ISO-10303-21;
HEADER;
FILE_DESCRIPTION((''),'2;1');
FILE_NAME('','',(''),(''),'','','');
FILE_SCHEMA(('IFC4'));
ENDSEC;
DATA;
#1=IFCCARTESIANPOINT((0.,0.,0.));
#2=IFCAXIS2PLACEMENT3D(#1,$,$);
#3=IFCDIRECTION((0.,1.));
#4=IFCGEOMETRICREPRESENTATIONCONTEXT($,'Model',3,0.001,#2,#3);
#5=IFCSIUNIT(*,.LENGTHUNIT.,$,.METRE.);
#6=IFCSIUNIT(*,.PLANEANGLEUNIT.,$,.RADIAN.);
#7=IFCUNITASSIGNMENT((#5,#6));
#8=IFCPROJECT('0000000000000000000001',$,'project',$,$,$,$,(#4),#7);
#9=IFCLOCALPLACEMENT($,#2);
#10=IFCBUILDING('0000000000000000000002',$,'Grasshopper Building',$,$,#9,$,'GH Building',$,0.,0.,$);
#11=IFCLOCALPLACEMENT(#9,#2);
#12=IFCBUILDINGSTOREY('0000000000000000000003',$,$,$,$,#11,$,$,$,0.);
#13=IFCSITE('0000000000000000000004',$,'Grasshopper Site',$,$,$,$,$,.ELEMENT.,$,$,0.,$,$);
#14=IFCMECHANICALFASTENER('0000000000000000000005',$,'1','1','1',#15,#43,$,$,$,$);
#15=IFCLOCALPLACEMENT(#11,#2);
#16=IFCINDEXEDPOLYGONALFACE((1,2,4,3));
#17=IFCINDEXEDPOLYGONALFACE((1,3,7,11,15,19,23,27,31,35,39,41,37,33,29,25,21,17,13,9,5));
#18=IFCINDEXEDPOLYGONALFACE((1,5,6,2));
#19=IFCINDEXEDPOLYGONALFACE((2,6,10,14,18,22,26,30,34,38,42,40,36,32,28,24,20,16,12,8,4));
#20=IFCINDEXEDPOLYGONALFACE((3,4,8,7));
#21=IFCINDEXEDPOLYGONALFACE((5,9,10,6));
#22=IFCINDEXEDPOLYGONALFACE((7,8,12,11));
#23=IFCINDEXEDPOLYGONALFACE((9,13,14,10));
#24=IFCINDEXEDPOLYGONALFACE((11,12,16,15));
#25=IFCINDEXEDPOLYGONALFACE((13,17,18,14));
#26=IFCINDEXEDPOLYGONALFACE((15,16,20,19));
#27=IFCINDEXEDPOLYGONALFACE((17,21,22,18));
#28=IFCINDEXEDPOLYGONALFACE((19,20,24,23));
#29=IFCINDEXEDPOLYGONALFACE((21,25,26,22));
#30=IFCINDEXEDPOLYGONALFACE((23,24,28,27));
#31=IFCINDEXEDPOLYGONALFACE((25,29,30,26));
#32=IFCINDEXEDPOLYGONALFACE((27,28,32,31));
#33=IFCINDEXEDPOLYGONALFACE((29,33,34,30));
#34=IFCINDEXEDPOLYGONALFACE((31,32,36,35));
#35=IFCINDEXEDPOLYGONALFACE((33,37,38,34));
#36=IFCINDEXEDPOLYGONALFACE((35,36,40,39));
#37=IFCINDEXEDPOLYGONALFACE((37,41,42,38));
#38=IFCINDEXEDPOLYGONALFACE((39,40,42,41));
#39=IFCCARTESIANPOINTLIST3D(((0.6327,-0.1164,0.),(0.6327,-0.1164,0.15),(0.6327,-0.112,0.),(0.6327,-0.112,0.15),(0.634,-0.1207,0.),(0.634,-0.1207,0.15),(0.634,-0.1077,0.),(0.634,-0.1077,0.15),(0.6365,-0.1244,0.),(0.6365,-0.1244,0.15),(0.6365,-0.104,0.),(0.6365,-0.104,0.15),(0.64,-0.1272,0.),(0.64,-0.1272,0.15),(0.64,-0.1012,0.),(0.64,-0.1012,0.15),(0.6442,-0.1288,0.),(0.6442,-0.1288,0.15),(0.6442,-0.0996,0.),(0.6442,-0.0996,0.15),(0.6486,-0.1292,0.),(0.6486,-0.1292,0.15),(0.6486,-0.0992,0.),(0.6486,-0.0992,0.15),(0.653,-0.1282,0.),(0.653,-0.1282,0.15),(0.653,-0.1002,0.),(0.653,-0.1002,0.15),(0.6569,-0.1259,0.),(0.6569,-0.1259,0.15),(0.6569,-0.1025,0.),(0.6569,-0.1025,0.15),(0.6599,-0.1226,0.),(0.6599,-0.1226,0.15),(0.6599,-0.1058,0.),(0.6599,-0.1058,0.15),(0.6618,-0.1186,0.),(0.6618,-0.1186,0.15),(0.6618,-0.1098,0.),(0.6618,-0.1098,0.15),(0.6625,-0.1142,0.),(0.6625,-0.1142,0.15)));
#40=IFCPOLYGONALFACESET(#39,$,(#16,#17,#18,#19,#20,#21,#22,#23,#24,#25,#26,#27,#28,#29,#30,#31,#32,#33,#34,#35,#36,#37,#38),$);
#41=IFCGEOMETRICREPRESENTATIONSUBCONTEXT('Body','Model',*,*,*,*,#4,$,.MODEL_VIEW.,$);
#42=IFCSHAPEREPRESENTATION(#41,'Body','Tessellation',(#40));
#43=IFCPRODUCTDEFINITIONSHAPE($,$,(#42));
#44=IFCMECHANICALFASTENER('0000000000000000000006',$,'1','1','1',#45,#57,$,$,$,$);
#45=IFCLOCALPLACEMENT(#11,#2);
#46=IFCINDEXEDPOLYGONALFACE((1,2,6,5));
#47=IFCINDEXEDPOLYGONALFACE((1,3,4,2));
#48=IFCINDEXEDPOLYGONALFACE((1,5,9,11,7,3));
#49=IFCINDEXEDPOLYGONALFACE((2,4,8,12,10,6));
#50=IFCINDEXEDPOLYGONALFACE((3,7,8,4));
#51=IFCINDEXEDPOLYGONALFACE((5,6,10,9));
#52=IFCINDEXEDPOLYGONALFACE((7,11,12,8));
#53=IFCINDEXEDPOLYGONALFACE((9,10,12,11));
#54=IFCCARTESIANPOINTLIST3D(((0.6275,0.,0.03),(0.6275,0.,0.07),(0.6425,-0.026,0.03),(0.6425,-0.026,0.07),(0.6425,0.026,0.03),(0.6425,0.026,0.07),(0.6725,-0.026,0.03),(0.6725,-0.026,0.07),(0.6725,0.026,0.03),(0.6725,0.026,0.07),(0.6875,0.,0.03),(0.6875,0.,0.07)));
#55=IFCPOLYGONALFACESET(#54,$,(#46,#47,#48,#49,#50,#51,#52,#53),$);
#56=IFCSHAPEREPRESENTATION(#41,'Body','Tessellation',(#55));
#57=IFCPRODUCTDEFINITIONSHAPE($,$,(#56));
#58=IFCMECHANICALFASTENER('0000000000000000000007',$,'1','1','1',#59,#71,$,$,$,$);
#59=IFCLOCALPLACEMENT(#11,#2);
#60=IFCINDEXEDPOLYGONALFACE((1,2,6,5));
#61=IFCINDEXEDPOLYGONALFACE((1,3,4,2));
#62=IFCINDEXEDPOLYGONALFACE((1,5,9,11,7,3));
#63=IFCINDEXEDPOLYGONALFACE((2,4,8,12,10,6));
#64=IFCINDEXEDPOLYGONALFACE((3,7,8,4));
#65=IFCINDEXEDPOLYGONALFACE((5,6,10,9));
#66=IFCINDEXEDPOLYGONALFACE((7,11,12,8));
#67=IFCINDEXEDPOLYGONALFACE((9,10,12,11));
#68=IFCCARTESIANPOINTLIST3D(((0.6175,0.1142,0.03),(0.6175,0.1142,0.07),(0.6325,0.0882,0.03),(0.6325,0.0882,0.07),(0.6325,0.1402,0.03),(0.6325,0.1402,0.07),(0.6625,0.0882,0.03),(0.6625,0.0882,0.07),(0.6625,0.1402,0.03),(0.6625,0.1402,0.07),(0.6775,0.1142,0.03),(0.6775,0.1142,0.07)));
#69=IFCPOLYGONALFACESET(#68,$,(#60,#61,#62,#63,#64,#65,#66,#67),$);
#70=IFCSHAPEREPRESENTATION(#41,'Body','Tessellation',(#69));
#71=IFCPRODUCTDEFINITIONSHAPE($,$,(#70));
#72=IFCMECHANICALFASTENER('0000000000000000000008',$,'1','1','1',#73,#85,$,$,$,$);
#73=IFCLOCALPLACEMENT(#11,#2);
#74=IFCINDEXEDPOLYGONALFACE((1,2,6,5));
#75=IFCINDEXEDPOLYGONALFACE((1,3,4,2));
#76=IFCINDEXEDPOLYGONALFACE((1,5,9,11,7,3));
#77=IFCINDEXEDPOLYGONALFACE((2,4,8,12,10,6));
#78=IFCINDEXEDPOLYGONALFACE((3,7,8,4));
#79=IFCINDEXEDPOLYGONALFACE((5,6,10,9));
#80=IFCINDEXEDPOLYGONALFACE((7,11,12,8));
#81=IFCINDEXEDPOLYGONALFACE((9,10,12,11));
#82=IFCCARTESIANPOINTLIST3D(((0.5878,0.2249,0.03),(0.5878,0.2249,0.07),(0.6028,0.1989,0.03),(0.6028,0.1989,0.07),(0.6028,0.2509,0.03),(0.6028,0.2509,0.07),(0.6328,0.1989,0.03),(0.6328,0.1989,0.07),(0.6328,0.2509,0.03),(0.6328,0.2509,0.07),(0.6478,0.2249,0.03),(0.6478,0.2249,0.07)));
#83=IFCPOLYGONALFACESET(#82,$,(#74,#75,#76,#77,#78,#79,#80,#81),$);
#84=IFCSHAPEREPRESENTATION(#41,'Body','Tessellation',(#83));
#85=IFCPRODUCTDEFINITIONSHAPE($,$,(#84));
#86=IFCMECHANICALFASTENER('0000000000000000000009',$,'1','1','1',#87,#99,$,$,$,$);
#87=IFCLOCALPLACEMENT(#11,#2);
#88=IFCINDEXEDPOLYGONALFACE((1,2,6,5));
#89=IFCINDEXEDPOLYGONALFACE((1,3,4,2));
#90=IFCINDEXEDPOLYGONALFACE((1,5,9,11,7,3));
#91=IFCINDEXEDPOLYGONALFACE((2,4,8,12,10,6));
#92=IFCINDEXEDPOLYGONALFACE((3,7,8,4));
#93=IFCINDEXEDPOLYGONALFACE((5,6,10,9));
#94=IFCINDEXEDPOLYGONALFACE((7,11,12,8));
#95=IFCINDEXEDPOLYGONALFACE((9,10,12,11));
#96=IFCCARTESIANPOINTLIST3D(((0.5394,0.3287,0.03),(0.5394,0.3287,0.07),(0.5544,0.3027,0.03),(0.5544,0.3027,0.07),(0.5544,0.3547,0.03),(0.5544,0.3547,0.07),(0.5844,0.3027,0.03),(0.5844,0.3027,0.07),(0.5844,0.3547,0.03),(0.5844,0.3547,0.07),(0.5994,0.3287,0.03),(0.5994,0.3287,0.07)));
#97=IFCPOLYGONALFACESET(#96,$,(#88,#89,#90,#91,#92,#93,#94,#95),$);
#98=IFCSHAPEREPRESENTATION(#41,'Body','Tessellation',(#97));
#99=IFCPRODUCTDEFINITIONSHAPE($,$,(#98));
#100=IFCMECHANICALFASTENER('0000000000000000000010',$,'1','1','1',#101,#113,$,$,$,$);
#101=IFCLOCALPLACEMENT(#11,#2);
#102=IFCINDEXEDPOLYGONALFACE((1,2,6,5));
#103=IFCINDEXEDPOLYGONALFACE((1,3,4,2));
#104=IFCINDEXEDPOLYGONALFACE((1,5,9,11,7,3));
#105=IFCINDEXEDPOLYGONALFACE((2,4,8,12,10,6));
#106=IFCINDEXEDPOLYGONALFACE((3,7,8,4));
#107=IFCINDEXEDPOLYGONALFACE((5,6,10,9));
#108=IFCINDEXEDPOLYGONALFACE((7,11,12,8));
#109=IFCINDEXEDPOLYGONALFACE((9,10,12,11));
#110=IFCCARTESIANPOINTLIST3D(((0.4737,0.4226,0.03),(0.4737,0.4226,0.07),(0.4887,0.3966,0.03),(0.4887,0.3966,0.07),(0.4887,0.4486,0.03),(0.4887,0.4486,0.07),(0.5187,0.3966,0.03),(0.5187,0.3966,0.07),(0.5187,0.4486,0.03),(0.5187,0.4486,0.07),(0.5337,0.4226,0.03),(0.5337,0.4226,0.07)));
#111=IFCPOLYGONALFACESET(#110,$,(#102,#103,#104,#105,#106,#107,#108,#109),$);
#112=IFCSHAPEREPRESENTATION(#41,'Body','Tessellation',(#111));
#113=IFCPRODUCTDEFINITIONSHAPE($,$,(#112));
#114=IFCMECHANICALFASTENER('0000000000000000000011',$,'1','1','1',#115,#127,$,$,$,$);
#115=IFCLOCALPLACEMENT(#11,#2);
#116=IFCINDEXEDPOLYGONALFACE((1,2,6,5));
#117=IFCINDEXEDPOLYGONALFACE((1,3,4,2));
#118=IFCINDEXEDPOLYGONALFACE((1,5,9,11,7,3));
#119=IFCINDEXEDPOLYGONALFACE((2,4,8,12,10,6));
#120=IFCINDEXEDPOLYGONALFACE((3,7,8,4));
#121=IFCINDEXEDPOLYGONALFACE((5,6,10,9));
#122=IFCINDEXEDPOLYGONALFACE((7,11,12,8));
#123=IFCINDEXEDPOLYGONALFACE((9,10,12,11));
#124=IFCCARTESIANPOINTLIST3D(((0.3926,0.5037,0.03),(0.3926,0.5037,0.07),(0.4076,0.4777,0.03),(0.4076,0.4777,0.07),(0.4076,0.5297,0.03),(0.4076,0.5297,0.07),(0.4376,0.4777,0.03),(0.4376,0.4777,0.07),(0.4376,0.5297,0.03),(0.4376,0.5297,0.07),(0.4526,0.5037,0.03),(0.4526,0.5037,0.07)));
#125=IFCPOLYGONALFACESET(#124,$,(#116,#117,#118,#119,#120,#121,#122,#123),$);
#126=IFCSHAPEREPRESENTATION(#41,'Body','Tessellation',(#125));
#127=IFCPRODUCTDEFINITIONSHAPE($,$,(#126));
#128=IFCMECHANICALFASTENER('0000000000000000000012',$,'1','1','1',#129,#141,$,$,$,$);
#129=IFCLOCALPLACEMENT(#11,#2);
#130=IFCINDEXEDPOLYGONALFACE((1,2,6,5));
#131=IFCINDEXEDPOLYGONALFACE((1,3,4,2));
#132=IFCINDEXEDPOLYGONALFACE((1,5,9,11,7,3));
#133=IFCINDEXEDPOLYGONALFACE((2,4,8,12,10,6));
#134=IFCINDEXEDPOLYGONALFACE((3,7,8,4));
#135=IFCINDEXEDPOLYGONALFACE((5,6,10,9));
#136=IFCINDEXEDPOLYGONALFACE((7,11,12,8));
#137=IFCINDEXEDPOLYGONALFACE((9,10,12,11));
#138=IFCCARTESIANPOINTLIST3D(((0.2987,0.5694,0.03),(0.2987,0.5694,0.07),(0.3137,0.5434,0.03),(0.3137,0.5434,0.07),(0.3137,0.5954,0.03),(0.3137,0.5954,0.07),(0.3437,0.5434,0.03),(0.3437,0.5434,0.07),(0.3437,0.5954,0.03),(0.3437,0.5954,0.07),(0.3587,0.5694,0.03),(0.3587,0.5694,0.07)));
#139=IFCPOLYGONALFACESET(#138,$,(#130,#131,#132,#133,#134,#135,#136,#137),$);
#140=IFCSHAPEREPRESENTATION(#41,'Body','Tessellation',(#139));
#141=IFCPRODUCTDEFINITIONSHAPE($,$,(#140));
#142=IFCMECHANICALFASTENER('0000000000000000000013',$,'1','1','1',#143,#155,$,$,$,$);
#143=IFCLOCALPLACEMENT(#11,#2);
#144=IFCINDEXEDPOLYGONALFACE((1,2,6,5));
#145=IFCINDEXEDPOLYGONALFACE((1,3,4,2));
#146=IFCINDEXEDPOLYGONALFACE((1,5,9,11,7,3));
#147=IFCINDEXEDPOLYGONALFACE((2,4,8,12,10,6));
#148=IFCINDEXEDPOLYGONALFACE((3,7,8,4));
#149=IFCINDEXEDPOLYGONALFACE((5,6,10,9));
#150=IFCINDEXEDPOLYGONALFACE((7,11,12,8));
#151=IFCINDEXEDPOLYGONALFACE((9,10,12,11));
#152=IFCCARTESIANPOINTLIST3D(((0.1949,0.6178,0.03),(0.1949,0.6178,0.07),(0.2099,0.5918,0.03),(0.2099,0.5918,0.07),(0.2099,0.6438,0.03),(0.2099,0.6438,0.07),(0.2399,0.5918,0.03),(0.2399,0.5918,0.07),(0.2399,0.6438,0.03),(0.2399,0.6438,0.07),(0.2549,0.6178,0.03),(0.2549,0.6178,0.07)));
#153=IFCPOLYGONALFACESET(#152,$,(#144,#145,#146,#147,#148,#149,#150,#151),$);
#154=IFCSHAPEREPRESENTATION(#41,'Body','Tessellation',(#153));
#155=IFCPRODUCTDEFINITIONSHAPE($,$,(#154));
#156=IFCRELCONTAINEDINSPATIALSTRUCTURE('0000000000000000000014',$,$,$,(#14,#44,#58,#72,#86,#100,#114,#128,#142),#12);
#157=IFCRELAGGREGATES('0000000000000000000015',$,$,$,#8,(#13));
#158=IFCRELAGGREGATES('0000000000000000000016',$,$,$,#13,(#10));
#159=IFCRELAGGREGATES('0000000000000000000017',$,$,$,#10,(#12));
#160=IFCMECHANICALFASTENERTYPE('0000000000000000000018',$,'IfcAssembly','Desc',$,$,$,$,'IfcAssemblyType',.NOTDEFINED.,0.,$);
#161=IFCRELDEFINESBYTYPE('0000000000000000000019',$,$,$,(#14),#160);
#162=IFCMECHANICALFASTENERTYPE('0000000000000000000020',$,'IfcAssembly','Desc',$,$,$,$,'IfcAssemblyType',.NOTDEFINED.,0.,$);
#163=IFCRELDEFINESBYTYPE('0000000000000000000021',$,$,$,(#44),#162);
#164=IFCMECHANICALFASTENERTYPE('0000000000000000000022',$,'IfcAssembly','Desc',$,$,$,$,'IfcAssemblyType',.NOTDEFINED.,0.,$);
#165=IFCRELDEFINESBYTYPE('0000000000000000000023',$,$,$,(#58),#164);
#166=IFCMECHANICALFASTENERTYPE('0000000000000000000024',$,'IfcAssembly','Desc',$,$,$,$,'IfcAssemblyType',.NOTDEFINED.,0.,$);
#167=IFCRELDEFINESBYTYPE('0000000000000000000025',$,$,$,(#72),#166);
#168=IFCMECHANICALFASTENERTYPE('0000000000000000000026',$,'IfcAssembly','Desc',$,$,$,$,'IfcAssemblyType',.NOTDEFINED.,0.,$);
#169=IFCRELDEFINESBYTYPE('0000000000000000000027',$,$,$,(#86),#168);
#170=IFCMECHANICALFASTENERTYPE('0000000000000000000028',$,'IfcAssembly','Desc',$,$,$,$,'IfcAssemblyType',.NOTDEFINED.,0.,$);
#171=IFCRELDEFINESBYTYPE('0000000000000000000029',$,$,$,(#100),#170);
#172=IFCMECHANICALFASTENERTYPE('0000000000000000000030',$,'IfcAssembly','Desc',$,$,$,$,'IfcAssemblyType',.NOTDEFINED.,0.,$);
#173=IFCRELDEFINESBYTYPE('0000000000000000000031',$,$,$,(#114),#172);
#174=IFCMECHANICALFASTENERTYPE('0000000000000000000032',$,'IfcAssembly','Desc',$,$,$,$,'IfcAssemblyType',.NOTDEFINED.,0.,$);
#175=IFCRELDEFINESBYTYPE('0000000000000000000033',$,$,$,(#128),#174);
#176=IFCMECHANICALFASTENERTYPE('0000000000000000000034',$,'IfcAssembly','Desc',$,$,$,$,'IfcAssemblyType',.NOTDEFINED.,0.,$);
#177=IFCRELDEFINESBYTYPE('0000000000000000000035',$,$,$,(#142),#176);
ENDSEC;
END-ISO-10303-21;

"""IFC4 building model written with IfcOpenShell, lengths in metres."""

from ifc_helpers import new_model, si_unit, direction, frame, origin, place, context, subcontext, project, spatial, indexed_curve, circle, outline, extrude, source, transform, mapped, type_object, type_shapes, element, save


model = new_model("IFC4")

# Units and contexts
model_context = context("Model", 3, precision=0.001, world=origin(), true_north=direction((0.0, 1.0)))
body_context = subcontext(model_context, "Body", "Model", "MODEL_VIEW")
ifc_project = project(units=[si_unit("LENGTHUNIT", "METRE"), si_unit("PLANEANGLEUNIT", "RADIAN")], contexts=[model_context])

# Site, building, storey
site = spatial("IfcSite", under=ifc_project, Name="Grasshopper Site", CompositionType="ELEMENT", RefElevation=0.0)
building_placement = place(None, origin())
building = spatial("IfcBuilding", under=site, at=building_placement, Name="Grasshopper Building", LongName="GH Building", ElevationOfRefHeight=0.0, ElevationOfTerrain=0.0)
storey_placement = place(building_placement, origin())
storey = spatial("IfcBuildingStorey", under=building, at=storey_placement, Elevation=0.0)

# Mechanical fasteners
mechanical_fastener_type_1 = type_object("IfcMechanicalFastenerType", Name="IfcAssembly", Description="Desc", ElementType="IfcAssemblyType", NominalDiameter=0.0)
shared_shape_1 = source(origin(), body_context, "Body", "SweptSolid", [
    extrude(circle(Radius=0.015), frame((0.6475, -0.1142, 0.0)), (0.0, 0.0, 1.0), 0.15),
])
type_shapes(mechanical_fastener_type_1, [shared_shape_1])
mechanical_fastener_1_placement = place(storey_placement, origin())
element("IfcMechanicalFastener", 1, at=mechanical_fastener_1_placement, inside=storey, type_object=mechanical_fastener_type_1, Name="1", Description="1", ObjectType="1", context=body_context, shape_type="MappedRepresentation", body=[
    mapped(shared_shape_1, transform((0.0, 0.0, 0.0), scale=1.0)),
])
mechanical_fastener_type_2 = type_object("IfcMechanicalFastenerType", Name="IfcAssembly", Description="Desc", ElementType="IfcAssemblyType", NominalDiameter=0.0)
shared_shape_2 = source(origin(), body_context, "Body", "SweptSolid", [
    extrude(outline(indexed_curve([(0.03, 0.0), (0.015, 0.026), (-0.015, 0.026), (-0.03, 0.0), (-0.015, -0.026), (0.015, -0.026), (0.03, 0.0)])), frame((0.6575, 0.0, 0.03)), (0.0, 0.0, 1.0), 0.04),
])
type_shapes(mechanical_fastener_type_2, [shared_shape_2])
mechanical_fastener_2_placement = place(storey_placement, origin())
element("IfcMechanicalFastener", 2, at=mechanical_fastener_2_placement, inside=storey, type_object=mechanical_fastener_type_2, Name="1", Description="1", ObjectType="1", context=body_context, shape_type="MappedRepresentation", body=[
    mapped(shared_shape_2, transform((0.0, 0.0, 0.0), scale=1.0)),
])
mechanical_fastener_type_3 = type_object("IfcMechanicalFastenerType", Name="IfcAssembly", Description="Desc", ElementType="IfcAssemblyType", NominalDiameter=0.0)
shared_shape_3 = source(origin(), body_context, "Body", "SweptSolid", [
    extrude(outline(indexed_curve([(0.03, 0.0), (0.015, 0.026), (-0.015, 0.026), (-0.03, 0.0), (-0.015, -0.026), (0.015, -0.026), (0.03, 0.0)])), frame((0.6475, 0.1142, 0.03)), (0.0, 0.0, 1.0), 0.04),
])
type_shapes(mechanical_fastener_type_3, [shared_shape_3])
mechanical_fastener_3_placement = place(storey_placement, origin())
element("IfcMechanicalFastener", 3, at=mechanical_fastener_3_placement, inside=storey, type_object=mechanical_fastener_type_3, Name="1", Description="1", ObjectType="1", context=body_context, shape_type="MappedRepresentation", body=[
    mapped(shared_shape_3, transform((0.0, 0.0, 0.0), scale=1.0)),
])
mechanical_fastener_type_4 = type_object("IfcMechanicalFastenerType", Name="IfcAssembly", Description="Desc", ElementType="IfcAssemblyType", NominalDiameter=0.0)
shared_shape_4 = source(origin(), body_context, "Body", "SweptSolid", [
    extrude(outline(indexed_curve([(0.03, 0.0), (0.015, 0.026), (-0.015, 0.026), (-0.03, 0.0), (-0.015, -0.026), (0.015, -0.026), (0.03, 0.0)])), frame((0.6178, 0.2249, 0.03)), (0.0, 0.0, 1.0), 0.04),
])
type_shapes(mechanical_fastener_type_4, [shared_shape_4])
mechanical_fastener_4_placement = place(storey_placement, origin())
element("IfcMechanicalFastener", 4, at=mechanical_fastener_4_placement, inside=storey, type_object=mechanical_fastener_type_4, Name="1", Description="1", ObjectType="1", context=body_context, shape_type="MappedRepresentation", body=[
    mapped(shared_shape_4, transform((0.0, 0.0, 0.0), scale=1.0)),
])
mechanical_fastener_type_5 = type_object("IfcMechanicalFastenerType", Name="IfcAssembly", Description="Desc", ElementType="IfcAssemblyType", NominalDiameter=0.0)
shared_shape_5 = source(origin(), body_context, "Body", "SweptSolid", [
    extrude(outline(indexed_curve([(0.03, 0.0), (0.015, 0.026), (-0.015, 0.026), (-0.03, 0.0), (-0.015, -0.026), (0.015, -0.026), (0.03, 0.0)])), frame((0.5694, 0.3287, 0.03)), (0.0, 0.0, 1.0), 0.04),
])
type_shapes(mechanical_fastener_type_5, [shared_shape_5])
mechanical_fastener_5_placement = place(storey_placement, origin())
element("IfcMechanicalFastener", 5, at=mechanical_fastener_5_placement, inside=storey, type_object=mechanical_fastener_type_5, Name="1", Description="1", ObjectType="1", context=body_context, shape_type="MappedRepresentation", body=[
    mapped(shared_shape_5, transform((0.0, 0.0, 0.0), scale=1.0)),
])
mechanical_fastener_type_6 = type_object("IfcMechanicalFastenerType", Name="IfcAssembly", Description="Desc", ElementType="IfcAssemblyType", NominalDiameter=0.0)
shared_shape_6 = source(origin(), body_context, "Body", "SweptSolid", [
    extrude(outline(indexed_curve([(0.03, 0.0), (0.015, 0.026), (-0.015, 0.026), (-0.03, 0.0), (-0.015, -0.026), (0.015, -0.026), (0.03, 0.0)])), frame((0.5037, 0.4226, 0.03)), (0.0, 0.0, 1.0), 0.04),
])
type_shapes(mechanical_fastener_type_6, [shared_shape_6])
mechanical_fastener_6_placement = place(storey_placement, origin())
element("IfcMechanicalFastener", 6, at=mechanical_fastener_6_placement, inside=storey, type_object=mechanical_fastener_type_6, Name="1", Description="1", ObjectType="1", context=body_context, shape_type="MappedRepresentation", body=[
    mapped(shared_shape_6, transform((0.0, 0.0, 0.0), scale=1.0)),
])
mechanical_fastener_type_7 = type_object("IfcMechanicalFastenerType", Name="IfcAssembly", Description="Desc", ElementType="IfcAssemblyType", NominalDiameter=0.0)
shared_shape_7 = source(origin(), body_context, "Body", "SweptSolid", [
    extrude(outline(indexed_curve([(0.03, 0.0), (0.015, 0.026), (-0.015, 0.026), (-0.03, 0.0), (-0.015, -0.026), (0.015, -0.026), (0.03, 0.0)])), frame((0.4226, 0.5037, 0.03)), (0.0, 0.0, 1.0), 0.04),
])
type_shapes(mechanical_fastener_type_7, [shared_shape_7])
mechanical_fastener_7_placement = place(storey_placement, origin())
element("IfcMechanicalFastener", 7, at=mechanical_fastener_7_placement, inside=storey, type_object=mechanical_fastener_type_7, Name="1", Description="1", ObjectType="1", context=body_context, shape_type="MappedRepresentation", body=[
    mapped(shared_shape_7, transform((0.0, 0.0, 0.0), scale=1.0)),
])
mechanical_fastener_type_8 = type_object("IfcMechanicalFastenerType", Name="IfcAssembly", Description="Desc", ElementType="IfcAssemblyType", NominalDiameter=0.0)
shared_shape_8 = source(origin(), body_context, "Body", "SweptSolid", [
    extrude(outline(indexed_curve([(0.03, 0.0), (0.015, 0.026), (-0.015, 0.026), (-0.03, 0.0), (-0.015, -0.026), (0.015, -0.026), (0.03, 0.0)])), frame((0.3287, 0.5694, 0.03)), (0.0, 0.0, 1.0), 0.04),
])
type_shapes(mechanical_fastener_type_8, [shared_shape_8])
mechanical_fastener_8_placement = place(storey_placement, origin())
element("IfcMechanicalFastener", 8, at=mechanical_fastener_8_placement, inside=storey, type_object=mechanical_fastener_type_8, Name="1", Description="1", ObjectType="1", context=body_context, shape_type="MappedRepresentation", body=[
    mapped(shared_shape_8, transform((0.0, 0.0, 0.0), scale=1.0)),
])
mechanical_fastener_type_9 = type_object("IfcMechanicalFastenerType", Name="IfcAssembly", Description="Desc", ElementType="IfcAssemblyType", NominalDiameter=0.0)
shared_shape_9 = source(origin(), body_context, "Body", "SweptSolid", [
    extrude(outline(indexed_curve([(0.03, 0.0), (0.015, 0.026), (-0.015, 0.026), (-0.03, 0.0), (-0.015, -0.026), (0.015, -0.026), (0.03, 0.0)])), frame((0.2249, 0.6178, 0.03)), (0.0, 0.0, 1.0), 0.04),
])
type_shapes(mechanical_fastener_type_9, [shared_shape_9])
mechanical_fastener_9_placement = place(storey_placement, origin())
element("IfcMechanicalFastener", 9, at=mechanical_fastener_9_placement, inside=storey, type_object=mechanical_fastener_type_9, Name="1", Description="1", ObjectType="1", context=body_context, shape_type="MappedRepresentation", body=[
    mapped(shared_shape_9, transform((0.0, 0.0, 0.0), scale=1.0)),
])

save(model, "model.ifc")
